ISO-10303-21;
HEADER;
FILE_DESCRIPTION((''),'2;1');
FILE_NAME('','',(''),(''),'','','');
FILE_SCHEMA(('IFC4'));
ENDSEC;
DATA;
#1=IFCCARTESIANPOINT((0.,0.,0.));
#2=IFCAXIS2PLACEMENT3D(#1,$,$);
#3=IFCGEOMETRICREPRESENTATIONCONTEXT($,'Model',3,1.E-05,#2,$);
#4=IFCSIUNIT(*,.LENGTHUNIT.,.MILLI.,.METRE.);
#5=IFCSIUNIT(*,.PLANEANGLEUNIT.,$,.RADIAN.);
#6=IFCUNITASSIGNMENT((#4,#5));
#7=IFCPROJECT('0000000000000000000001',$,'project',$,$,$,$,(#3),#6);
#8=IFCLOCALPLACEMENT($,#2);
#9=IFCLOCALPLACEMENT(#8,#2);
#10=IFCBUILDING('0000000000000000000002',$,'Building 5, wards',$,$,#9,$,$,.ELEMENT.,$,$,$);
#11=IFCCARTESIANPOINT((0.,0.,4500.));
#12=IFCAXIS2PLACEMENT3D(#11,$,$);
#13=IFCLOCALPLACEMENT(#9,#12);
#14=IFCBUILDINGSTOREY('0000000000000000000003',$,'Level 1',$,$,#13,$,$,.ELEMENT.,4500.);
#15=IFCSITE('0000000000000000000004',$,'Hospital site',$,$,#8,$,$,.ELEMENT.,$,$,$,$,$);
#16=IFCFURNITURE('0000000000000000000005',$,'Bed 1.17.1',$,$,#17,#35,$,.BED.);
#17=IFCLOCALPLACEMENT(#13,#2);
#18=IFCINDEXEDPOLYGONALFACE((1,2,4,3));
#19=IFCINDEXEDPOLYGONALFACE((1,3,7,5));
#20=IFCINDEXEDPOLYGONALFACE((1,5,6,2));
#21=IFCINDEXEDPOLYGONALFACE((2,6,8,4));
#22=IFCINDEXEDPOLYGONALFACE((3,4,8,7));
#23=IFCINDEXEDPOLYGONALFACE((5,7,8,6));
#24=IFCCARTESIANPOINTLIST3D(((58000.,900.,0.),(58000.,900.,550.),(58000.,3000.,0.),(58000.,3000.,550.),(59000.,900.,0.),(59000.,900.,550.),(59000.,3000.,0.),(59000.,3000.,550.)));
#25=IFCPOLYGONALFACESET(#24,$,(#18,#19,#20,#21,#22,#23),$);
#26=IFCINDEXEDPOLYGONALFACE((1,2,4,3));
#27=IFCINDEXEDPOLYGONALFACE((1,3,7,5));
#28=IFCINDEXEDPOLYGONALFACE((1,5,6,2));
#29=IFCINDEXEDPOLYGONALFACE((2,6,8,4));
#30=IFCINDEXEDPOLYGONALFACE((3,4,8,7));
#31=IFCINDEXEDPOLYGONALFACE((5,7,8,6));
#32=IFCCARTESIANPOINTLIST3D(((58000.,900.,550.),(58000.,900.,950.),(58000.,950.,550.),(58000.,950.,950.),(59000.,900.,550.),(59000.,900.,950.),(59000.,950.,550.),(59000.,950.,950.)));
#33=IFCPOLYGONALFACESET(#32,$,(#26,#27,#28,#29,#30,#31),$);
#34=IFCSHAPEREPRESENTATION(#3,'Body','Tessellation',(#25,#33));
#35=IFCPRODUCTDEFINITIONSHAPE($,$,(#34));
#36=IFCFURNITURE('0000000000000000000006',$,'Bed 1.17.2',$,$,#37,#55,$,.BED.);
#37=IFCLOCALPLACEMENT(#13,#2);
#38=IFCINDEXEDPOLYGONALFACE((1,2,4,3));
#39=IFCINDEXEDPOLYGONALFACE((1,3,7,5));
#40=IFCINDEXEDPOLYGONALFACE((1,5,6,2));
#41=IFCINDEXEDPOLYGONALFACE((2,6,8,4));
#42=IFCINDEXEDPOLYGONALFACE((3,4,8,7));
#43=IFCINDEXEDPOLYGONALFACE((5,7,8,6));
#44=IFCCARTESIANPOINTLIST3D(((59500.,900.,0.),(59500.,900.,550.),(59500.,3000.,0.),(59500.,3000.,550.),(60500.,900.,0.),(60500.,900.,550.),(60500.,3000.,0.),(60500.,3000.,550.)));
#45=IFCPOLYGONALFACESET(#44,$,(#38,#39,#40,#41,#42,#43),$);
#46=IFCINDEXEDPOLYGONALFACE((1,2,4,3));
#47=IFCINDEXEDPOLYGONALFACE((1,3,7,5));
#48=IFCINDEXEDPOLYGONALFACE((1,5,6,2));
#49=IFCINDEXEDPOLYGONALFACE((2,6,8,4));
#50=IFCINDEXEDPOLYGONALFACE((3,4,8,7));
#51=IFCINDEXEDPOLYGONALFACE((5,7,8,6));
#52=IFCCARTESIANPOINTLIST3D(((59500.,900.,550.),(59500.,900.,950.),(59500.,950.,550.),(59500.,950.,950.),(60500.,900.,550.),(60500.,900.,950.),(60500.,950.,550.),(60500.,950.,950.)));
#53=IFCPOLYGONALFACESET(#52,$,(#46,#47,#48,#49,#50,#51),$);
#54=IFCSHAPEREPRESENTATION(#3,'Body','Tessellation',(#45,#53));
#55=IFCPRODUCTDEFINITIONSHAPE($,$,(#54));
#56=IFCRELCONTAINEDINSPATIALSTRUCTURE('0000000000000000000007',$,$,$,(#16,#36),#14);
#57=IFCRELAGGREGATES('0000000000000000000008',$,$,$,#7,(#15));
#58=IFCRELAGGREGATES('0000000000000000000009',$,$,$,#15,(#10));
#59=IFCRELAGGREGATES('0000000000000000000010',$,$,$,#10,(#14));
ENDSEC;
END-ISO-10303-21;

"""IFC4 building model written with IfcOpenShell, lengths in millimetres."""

from ifc_helpers import new_model, si_unit, frame, frame_2d, origin, place, context, project, spatial, rectangle, extrude, element, save


model = new_model("IFC4")

# Units and contexts
model_context = context("Model", 3, precision=1e-05, world=origin())
ifc_project = project(units=[si_unit("LENGTHUNIT", "METRE", prefix="MILLI"), si_unit("PLANEANGLEUNIT", "RADIAN")], contexts=[model_context])

# Site, building, storey
site_placement = place(None, origin())
site = spatial("IfcSite", under=ifc_project, at=site_placement, Name="Hospital site", CompositionType="ELEMENT")
building_placement = place(site_placement, origin())
building = spatial("IfcBuilding", under=site, at=building_placement, Name="Building 5, wards", CompositionType="ELEMENT")
storey_placement = place(building_placement, frame((0.0, 0.0, 4500.0)))
storey = spatial("IfcBuildingStorey", under=building, at=storey_placement, Name="Level 1", CompositionType="ELEMENT", Elevation=4500.0)

# Furniture
for number, where, name in (
    (1, (58000.0, 900.0, 0.0), "Bed 1.17.1"),
    (2, (59500.0, 900.0, 0.0), "Bed 1.17.2"),
):
    element("IfcFurniture", number, at=place(storey_placement, frame(where)), inside=storey, Name=name, PredefinedType="BED", context=model_context, shape_type="SweptSolid", body=[
        extrude(rectangle(XDim=1000.0, YDim=2100.0, at=frame_2d((500.0, 1050.0))), origin(), (0.0, 0.0, 1.0), 550.0),
        extrude(rectangle(XDim=1000.0, YDim=50.0, at=frame_2d((500.0, 25.0))), frame((0.0, 0.0, 550.0)), (0.0, 0.0, 1.0), 400.0),
    ])

save(model, "model.ifc")
